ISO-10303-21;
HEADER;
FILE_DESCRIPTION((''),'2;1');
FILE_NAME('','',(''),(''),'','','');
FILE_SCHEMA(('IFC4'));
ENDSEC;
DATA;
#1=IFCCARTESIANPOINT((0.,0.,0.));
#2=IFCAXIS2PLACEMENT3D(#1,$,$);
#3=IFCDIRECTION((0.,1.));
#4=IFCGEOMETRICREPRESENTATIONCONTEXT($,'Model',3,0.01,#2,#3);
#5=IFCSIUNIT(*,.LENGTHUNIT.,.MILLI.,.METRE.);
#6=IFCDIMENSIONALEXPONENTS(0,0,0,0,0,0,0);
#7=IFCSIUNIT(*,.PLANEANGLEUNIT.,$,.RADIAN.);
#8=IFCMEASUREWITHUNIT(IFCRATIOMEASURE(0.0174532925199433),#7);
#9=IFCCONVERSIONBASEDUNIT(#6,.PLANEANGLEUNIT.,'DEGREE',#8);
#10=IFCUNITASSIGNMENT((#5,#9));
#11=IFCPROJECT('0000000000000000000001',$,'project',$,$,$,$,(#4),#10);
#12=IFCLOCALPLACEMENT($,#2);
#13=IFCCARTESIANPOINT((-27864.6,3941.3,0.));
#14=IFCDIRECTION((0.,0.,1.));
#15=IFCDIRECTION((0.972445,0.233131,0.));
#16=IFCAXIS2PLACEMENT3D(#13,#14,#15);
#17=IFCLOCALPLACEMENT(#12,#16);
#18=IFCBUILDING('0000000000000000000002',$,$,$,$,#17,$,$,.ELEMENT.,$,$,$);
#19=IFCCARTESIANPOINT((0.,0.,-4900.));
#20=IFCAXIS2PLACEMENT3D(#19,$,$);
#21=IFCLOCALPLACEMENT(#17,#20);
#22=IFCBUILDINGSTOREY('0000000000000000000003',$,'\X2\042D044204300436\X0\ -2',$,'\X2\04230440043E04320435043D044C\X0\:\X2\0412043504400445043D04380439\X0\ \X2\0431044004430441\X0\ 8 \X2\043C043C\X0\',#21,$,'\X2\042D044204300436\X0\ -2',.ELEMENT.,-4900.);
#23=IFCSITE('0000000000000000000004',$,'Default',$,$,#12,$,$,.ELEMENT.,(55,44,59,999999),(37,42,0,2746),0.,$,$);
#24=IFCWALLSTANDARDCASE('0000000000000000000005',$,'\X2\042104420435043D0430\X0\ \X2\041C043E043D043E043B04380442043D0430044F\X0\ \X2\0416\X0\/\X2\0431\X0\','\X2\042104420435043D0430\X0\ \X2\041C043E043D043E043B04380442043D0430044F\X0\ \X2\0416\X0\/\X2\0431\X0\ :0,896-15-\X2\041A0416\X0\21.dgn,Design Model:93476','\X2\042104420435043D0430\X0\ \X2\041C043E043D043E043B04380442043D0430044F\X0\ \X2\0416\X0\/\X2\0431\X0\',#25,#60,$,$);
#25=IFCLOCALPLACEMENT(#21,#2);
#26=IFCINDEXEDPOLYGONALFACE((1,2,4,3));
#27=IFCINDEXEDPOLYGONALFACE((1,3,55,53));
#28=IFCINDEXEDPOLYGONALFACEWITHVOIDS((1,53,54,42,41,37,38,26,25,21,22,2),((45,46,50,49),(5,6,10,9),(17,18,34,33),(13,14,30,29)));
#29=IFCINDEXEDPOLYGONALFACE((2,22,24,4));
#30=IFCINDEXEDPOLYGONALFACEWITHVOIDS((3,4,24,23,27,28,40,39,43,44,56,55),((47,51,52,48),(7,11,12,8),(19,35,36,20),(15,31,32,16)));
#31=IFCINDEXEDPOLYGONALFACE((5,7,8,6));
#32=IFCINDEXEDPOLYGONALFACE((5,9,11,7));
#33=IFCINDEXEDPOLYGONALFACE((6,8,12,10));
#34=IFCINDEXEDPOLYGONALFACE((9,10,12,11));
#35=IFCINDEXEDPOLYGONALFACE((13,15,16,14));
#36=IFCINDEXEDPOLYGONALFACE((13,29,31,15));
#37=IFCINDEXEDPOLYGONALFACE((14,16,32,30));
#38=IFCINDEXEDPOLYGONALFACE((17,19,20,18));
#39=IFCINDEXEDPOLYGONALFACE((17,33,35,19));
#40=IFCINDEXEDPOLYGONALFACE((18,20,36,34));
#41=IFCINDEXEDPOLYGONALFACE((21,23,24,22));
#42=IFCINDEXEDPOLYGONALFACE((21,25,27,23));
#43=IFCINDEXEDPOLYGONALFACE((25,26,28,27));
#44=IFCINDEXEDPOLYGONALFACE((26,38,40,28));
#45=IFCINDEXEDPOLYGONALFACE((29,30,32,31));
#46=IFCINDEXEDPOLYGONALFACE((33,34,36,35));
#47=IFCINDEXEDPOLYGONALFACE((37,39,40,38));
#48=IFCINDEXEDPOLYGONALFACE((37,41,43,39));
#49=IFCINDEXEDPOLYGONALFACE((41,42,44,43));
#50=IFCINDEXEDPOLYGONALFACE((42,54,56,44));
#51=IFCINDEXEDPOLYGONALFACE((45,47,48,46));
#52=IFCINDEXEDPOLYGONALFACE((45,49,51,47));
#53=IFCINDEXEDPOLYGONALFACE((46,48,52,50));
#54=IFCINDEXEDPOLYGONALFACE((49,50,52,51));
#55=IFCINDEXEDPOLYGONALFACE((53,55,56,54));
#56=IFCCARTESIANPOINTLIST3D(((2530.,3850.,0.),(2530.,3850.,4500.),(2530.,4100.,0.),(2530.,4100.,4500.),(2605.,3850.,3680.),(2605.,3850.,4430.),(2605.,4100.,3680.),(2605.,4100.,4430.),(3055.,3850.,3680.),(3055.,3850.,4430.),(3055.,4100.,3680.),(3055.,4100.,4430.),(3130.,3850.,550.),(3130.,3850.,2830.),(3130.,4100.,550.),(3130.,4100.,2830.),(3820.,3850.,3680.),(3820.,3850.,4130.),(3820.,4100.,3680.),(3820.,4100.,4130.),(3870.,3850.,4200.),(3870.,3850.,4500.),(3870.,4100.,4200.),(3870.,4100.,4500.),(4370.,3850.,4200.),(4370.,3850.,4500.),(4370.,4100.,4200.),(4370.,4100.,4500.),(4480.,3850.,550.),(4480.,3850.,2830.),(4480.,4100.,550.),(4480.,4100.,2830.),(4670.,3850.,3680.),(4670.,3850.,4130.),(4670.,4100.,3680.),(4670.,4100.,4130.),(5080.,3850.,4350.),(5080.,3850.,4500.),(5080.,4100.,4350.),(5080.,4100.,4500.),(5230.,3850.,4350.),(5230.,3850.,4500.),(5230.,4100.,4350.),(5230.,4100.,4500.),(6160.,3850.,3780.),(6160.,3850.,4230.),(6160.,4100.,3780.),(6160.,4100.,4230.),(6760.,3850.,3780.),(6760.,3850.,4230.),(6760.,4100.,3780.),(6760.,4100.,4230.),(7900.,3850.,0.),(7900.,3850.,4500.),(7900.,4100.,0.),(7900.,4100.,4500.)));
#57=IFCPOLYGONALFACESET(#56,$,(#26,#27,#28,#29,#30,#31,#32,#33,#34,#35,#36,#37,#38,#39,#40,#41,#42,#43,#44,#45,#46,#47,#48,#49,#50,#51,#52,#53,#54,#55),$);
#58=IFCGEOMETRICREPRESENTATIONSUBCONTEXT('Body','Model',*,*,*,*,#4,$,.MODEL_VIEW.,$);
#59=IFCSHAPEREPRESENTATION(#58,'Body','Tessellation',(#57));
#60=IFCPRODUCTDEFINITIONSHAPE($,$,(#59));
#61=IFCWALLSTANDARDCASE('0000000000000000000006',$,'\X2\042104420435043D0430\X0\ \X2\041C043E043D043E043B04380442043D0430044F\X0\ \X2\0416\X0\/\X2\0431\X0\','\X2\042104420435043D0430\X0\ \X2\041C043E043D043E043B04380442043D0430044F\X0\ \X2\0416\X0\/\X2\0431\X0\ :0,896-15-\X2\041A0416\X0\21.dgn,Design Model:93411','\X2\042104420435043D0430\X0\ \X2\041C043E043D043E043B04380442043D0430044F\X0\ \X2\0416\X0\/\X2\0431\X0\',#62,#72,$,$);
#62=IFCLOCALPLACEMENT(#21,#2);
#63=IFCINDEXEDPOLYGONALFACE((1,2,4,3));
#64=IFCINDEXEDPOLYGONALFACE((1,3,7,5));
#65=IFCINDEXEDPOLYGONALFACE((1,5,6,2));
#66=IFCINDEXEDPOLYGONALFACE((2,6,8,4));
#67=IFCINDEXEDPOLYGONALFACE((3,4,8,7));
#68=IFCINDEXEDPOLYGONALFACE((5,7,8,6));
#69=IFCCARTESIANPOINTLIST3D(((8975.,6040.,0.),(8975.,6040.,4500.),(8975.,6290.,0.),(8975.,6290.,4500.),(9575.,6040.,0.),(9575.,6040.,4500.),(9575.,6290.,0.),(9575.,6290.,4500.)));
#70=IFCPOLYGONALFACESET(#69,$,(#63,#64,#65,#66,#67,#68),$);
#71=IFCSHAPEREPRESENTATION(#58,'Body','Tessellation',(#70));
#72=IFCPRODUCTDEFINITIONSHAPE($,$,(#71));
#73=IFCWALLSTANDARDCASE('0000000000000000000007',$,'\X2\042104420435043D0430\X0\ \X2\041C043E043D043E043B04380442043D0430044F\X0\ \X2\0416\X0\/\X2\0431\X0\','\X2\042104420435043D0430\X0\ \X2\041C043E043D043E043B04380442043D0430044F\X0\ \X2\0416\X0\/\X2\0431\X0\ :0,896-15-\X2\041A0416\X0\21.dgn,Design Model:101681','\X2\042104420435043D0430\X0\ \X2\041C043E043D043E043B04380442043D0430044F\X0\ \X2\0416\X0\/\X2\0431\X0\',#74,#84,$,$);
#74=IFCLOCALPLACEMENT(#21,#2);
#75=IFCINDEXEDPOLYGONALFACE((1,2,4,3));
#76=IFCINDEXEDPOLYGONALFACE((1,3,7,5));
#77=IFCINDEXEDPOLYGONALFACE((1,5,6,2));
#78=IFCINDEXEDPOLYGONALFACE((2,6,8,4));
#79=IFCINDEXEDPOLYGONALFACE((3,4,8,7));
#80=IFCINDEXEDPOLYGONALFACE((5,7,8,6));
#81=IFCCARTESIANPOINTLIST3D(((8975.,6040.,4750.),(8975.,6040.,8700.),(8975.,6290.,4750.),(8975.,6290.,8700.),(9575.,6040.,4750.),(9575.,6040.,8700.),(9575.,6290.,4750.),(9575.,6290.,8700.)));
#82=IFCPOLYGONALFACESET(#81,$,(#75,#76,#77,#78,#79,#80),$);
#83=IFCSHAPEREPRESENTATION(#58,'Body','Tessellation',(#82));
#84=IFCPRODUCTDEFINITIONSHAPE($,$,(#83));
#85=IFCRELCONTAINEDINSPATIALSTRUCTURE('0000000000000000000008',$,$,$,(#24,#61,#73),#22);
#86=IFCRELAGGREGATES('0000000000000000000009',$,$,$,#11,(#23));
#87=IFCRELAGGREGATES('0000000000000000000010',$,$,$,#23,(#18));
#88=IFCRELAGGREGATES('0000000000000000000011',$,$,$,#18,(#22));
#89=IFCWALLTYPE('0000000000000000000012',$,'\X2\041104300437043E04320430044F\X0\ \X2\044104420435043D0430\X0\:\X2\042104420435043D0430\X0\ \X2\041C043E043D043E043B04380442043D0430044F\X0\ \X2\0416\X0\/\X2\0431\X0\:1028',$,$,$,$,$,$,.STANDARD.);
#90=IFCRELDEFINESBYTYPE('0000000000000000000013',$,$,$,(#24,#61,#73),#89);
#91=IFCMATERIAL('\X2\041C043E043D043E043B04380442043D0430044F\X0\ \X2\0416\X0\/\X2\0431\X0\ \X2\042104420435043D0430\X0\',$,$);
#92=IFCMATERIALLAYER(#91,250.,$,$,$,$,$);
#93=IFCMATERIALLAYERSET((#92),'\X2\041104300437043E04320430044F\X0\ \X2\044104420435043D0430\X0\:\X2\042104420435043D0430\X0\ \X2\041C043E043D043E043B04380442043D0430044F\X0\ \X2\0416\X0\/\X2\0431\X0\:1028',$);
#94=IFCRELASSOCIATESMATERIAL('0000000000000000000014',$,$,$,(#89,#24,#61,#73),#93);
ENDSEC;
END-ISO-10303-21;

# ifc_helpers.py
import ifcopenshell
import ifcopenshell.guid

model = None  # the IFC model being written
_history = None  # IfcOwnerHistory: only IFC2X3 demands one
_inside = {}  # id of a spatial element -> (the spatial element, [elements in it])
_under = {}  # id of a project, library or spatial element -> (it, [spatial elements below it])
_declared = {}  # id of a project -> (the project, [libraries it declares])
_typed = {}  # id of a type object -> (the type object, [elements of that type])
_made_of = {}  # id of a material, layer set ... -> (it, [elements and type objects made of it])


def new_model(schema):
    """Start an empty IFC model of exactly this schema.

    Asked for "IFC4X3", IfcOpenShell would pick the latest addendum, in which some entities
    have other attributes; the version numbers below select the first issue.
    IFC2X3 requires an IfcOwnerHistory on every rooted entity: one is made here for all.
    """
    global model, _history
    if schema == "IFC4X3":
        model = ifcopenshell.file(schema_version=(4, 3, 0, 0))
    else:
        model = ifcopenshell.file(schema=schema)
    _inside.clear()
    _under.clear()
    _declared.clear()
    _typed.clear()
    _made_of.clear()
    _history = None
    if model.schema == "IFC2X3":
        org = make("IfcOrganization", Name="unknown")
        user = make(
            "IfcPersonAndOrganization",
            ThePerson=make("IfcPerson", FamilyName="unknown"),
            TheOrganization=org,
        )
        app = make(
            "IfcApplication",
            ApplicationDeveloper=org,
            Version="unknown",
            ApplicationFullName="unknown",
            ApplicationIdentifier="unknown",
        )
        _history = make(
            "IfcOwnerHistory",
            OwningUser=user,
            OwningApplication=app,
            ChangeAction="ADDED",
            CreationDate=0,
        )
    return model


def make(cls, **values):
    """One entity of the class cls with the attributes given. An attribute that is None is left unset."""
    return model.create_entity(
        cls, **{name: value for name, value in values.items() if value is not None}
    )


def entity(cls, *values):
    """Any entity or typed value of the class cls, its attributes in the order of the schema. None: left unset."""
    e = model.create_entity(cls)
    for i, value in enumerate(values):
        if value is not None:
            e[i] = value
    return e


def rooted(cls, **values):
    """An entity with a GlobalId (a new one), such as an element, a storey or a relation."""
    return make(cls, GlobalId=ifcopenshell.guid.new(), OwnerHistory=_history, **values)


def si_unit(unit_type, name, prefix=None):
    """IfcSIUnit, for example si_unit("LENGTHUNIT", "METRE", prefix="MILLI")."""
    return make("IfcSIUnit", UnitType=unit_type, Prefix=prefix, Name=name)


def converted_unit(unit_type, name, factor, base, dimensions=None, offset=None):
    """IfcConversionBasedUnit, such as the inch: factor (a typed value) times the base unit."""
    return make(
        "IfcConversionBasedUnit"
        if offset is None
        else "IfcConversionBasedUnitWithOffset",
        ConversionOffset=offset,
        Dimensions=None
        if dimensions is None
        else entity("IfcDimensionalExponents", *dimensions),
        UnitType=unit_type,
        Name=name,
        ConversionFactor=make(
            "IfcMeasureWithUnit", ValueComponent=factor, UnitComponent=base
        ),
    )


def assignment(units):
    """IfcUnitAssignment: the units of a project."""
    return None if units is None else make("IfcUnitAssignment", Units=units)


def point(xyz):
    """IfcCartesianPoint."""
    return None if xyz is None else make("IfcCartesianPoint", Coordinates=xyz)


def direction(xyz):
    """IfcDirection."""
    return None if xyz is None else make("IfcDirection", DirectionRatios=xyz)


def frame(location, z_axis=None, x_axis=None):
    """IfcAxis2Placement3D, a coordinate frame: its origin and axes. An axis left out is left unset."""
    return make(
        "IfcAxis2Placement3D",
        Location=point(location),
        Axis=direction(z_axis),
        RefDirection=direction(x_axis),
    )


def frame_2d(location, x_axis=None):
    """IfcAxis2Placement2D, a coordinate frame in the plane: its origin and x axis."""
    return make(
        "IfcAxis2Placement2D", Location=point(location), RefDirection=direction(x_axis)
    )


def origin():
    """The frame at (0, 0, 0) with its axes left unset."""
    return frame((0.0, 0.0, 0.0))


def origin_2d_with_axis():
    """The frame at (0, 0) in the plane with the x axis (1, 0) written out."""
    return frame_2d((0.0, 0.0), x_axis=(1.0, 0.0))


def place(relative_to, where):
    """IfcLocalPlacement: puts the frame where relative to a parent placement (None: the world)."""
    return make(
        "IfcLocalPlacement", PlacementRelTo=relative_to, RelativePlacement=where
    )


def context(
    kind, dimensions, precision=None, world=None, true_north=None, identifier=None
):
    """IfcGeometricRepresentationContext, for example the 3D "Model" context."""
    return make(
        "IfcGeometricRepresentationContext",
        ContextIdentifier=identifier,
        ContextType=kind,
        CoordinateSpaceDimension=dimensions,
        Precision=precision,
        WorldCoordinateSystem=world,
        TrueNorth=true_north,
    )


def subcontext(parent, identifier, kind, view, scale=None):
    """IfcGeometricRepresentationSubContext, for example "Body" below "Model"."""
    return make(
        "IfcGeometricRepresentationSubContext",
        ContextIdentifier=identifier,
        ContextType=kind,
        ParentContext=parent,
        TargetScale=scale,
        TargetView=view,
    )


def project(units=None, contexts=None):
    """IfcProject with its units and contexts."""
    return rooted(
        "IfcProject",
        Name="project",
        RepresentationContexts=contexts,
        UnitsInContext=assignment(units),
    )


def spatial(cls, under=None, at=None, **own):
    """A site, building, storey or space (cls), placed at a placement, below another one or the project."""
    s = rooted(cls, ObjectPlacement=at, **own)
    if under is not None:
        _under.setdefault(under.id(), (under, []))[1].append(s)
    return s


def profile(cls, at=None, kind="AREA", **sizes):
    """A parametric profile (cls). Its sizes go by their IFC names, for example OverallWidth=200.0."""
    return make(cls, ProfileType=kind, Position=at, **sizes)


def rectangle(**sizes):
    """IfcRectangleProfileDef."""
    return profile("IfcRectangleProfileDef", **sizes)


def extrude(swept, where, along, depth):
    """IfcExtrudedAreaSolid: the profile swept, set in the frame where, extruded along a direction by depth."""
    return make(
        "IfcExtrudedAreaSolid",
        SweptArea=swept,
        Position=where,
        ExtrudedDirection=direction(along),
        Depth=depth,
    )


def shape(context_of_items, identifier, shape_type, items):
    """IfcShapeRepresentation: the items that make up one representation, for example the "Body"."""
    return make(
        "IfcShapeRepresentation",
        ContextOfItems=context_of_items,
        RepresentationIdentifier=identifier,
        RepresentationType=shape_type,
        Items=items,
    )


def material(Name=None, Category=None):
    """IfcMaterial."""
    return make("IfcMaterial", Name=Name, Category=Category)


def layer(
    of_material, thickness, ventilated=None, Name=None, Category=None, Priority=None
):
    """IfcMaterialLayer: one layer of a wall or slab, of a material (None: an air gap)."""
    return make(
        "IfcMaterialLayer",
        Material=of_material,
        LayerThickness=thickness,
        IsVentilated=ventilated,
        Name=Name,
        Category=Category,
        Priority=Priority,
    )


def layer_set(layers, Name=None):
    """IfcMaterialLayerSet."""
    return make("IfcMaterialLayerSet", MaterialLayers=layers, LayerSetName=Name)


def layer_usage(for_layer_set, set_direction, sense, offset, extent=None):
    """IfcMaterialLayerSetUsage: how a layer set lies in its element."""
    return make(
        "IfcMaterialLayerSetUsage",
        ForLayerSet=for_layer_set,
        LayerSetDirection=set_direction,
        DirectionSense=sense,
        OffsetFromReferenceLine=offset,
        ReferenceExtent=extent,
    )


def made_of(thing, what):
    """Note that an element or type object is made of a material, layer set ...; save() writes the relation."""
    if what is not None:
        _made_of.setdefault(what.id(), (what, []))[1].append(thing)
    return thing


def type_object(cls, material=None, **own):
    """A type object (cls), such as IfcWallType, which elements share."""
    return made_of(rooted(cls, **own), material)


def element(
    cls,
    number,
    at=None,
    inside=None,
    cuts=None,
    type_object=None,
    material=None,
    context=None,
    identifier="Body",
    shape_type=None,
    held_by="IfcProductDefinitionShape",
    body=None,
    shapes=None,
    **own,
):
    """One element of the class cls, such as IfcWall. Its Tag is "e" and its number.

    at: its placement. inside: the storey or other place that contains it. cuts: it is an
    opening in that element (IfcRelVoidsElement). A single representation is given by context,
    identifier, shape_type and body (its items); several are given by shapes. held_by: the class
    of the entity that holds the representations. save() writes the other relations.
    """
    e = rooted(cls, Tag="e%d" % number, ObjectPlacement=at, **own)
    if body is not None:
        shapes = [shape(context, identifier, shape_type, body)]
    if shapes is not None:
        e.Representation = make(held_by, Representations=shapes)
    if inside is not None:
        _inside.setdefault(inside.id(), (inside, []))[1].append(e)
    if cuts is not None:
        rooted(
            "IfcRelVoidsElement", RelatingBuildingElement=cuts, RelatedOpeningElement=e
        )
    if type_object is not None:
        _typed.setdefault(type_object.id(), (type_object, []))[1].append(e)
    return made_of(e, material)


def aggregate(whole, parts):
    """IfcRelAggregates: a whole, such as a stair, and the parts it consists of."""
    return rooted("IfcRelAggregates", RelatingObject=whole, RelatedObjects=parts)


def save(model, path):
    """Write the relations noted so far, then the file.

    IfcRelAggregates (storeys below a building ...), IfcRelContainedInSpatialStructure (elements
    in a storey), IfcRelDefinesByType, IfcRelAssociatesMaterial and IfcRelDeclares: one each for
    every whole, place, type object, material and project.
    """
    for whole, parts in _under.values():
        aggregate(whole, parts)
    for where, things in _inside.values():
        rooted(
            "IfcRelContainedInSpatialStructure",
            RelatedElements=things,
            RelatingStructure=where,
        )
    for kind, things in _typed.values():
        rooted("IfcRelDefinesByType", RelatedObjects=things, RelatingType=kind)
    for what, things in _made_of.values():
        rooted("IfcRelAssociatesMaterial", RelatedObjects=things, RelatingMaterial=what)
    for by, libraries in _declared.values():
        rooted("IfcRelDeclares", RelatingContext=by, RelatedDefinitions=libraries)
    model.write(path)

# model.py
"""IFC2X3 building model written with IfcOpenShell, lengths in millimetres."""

from ifc_helpers import new_model, entity, si_unit, converted_unit, direction, frame, frame_2d, origin, origin_2d_with_axis, place, context, subcontext, project, spatial, rectangle, extrude, material, layer, layer_set, layer_usage, type_object, element, save


model = new_model("IFC2X3")

# Units and contexts
model_context = context("Model", 3, precision=0.01, world=origin(), true_north=direction((0.0, 1.0)))
body_context = subcontext(model_context, "Body", "Model", "MODEL_VIEW")
ifc_project = project(units=[si_unit("LENGTHUNIT", "METRE", prefix="MILLI"), converted_unit("PLANEANGLEUNIT", "DEGREE", entity("IfcRatioMeasure", 0.0174532925199433), si_unit("PLANEANGLEUNIT", "RADIAN"), dimensions=[0, 0, 0, 0, 0, 0, 0])], contexts=[model_context])

# Site, building, storey
site_placement = place(None, origin())
site = spatial("IfcSite", under=ifc_project, at=site_placement, Name="Default", CompositionType="ELEMENT", RefLatitude=(55, 44, 59, 999999), RefLongitude=(37, 42, 0, 2746), RefElevation=0.0)
building_placement = place(site_placement, frame((-27864.6, 3941.3, 0.0), z_axis=(0.0, 0.0, 1.0), x_axis=(0.972445, 0.233131, 0.0)))
building = spatial("IfcBuilding", under=site, at=building_placement, CompositionType="ELEMENT")
storey_placement = place(building_placement, frame((0.0, 0.0, -4900.0)))
storey = spatial("IfcBuildingStorey", under=building, at=storey_placement, Name="Этаж -2", ObjectType="Уровень:Верхний брус 8 мм", LongName="Этаж -2", CompositionType="ELEMENT", Elevation=-4900.0)

# Shared definitions
ifc_material = material(Name="Монолитная Ж/б Стена")

# Wall, openings
ifc_layer_1 = layer(ifc_material, 250.0)
ifc_layer_set_1 = layer_set([ifc_layer_1], Name="Базовая стена:Стена Монолитная Ж/б:1028")
ifc_layer_usage_1 = layer_usage(ifc_layer_set_1, "AXIS2", "NEGATIVE", 125.0)
wall_type_1 = type_object("IfcWallType", Name="Базовая стена:Стена Монолитная Ж/б:1028", PredefinedType="STANDARD", material=ifc_layer_set_1)
wall_1_placement = place(storey_placement, frame((7900.0, 3975.0, 0.0), z_axis=(0.0, 0.0, 1.0), x_axis=(-1.0, 0.0, 0.0)))
wall_1 = element("IfcWallStandardCase", 1, at=wall_1_placement, inside=storey, type_object=wall_type_1, material=ifc_layer_usage_1, Name="Стена Монолитная Ж/б", Description="Стена Монолитная Ж/б :0,896-15-КЖ21.dgn,Design Model:93476", ObjectType="Стена Монолитная Ж/б", context=body_context, shape_type="SweptSolid", body=[
    extrude(rectangle(XDim=5370.0, YDim=250.0, at=frame_2d((2685.0, 0.0), x_axis=(-1.0, 0.0))), origin(), (0.0, 0.0, 1.0), 4500.0),
])
placement_1 = place(wall_1_placement, origin())
element("IfcOpeningElement", 2, at=placement_1, cuts=wall_1, ObjectType="Opening", context=body_context, shape_type="SweptSolid", body=[
    extrude(rectangle(XDim=2280.0, YDim=1350.0, at=origin_2d_with_axis()), frame((4095.0, -125.0, 1690.0), z_axis=(0.0, 1.0, 0.0), x_axis=(0.0, 0.0, -1.0)), (0.0, 0.0, 1.0), 250.0),
])
element("IfcOpeningElement", 3, at=placement_1, cuts=wall_1, ObjectType="Opening", context=body_context, shape_type="SweptSolid", body=[
    extrude(rectangle(XDim=750.0, YDim=450.0, at=origin_2d_with_axis()), frame((5070.0, -125.0, 4055.0), z_axis=(0.0, 1.0, 0.0), x_axis=(0.0, 0.0, -1.0)), (0.0, 0.0, 1.0), 250.0),
])
element("IfcOpeningElement", 4, at=placement_1, cuts=wall_1, ObjectType="Opening", context=body_context, shape_type="SweptSolid", body=[
    extrude(rectangle(XDim=450.0, YDim=850.0, at=origin_2d_with_axis()), frame((3655.0, -125.0, 3905.0), z_axis=(0.0, 1.0, 0.0), x_axis=(0.0, 0.0, -1.0)), (0.0, 0.0, 1.0), 250.0),
])
element("IfcOpeningElement", 5, at=placement_1, cuts=wall_1, ObjectType="Opening", context=body_context, shape_type="SweptSolid", body=[
    extrude(rectangle(XDim=300.0, YDim=500.0, at=origin_2d_with_axis()), frame((3780.0, -125.0, 4350.0), z_axis=(0.0, 1.0, 0.0), x_axis=(0.0, 0.0, -1.0)), (0.0, 0.0, 1.0), 250.0),
])
element("IfcOpeningElement", 6, at=placement_1, cuts=wall_1, ObjectType="Opening", context=body_context, shape_type="SweptSolid", body=[
    extrude(rectangle(XDim=150.0, YDim=150.0, at=origin_2d_with_axis()), frame((2745.0, -125.0, 4425.0), z_axis=(0.0, 1.0, 0.0), x_axis=(0.0, 0.0, -1.0)), (0.0, 0.0, 1.0), 250.0),
])
element("IfcOpeningElement", 7, at=placement_1, cuts=wall_1, ObjectType="Opening", context=body_context, shape_type="SweptSolid", body=[
    extrude(rectangle(XDim=450.0, YDim=600.0, at=origin_2d_with_axis()), frame((1440.0, -125.0, 4005.0), z_axis=(0.0, 1.0, 0.0), x_axis=(0.0, 0.0, -1.0)), (0.0, 0.0, 1.0), 250.0),
])

# Walls
wall_2_placement = place(storey_placement, frame((9575.0, 6165.0, 0.0), z_axis=(0.0, 0.0, 1.0), x_axis=(-1.0, 0.0, 0.0)))
element("IfcWallStandardCase", 8, at=wall_2_placement, inside=storey, type_object=wall_type_1, material=ifc_layer_usage_1, Name="Стена Монолитная Ж/б", Description="Стена Монолитная Ж/б :0,896-15-КЖ21.dgn,Design Model:93411", ObjectType="Стена Монолитная Ж/б", context=body_context, shape_type="SweptSolid", body=[
    extrude(rectangle(XDim=600.0, YDim=250.0, at=frame_2d((300.0, 0.0), x_axis=(-1.0, 0.0))), origin(), (0.0, 0.0, 1.0), 4500.0),
])
wall_3_placement = place(storey_placement, frame((9575.0, 6165.0, 4750.0), z_axis=(0.0, 0.0, 1.0), x_axis=(-1.0, 0.0, 0.0)))
element("IfcWallStandardCase", 9, at=wall_3_placement, inside=storey, type_object=wall_type_1, material=ifc_layer_usage_1, Name="Стена Монолитная Ж/б", Description="Стена Монолитная Ж/б :0,896-15-КЖ21.dgn,Design Model:101681", ObjectType="Стена Монолитная Ж/б", context=body_context, shape_type="SweptSolid", body=[
    extrude(rectangle(XDim=600.0, YDim=250.0, at=frame_2d((300.0, 0.0), x_axis=(-1.0, 0.0))), origin(), (0.0, 0.0, 1.0), 3950.0),
])

save(model, "model.ifc")
